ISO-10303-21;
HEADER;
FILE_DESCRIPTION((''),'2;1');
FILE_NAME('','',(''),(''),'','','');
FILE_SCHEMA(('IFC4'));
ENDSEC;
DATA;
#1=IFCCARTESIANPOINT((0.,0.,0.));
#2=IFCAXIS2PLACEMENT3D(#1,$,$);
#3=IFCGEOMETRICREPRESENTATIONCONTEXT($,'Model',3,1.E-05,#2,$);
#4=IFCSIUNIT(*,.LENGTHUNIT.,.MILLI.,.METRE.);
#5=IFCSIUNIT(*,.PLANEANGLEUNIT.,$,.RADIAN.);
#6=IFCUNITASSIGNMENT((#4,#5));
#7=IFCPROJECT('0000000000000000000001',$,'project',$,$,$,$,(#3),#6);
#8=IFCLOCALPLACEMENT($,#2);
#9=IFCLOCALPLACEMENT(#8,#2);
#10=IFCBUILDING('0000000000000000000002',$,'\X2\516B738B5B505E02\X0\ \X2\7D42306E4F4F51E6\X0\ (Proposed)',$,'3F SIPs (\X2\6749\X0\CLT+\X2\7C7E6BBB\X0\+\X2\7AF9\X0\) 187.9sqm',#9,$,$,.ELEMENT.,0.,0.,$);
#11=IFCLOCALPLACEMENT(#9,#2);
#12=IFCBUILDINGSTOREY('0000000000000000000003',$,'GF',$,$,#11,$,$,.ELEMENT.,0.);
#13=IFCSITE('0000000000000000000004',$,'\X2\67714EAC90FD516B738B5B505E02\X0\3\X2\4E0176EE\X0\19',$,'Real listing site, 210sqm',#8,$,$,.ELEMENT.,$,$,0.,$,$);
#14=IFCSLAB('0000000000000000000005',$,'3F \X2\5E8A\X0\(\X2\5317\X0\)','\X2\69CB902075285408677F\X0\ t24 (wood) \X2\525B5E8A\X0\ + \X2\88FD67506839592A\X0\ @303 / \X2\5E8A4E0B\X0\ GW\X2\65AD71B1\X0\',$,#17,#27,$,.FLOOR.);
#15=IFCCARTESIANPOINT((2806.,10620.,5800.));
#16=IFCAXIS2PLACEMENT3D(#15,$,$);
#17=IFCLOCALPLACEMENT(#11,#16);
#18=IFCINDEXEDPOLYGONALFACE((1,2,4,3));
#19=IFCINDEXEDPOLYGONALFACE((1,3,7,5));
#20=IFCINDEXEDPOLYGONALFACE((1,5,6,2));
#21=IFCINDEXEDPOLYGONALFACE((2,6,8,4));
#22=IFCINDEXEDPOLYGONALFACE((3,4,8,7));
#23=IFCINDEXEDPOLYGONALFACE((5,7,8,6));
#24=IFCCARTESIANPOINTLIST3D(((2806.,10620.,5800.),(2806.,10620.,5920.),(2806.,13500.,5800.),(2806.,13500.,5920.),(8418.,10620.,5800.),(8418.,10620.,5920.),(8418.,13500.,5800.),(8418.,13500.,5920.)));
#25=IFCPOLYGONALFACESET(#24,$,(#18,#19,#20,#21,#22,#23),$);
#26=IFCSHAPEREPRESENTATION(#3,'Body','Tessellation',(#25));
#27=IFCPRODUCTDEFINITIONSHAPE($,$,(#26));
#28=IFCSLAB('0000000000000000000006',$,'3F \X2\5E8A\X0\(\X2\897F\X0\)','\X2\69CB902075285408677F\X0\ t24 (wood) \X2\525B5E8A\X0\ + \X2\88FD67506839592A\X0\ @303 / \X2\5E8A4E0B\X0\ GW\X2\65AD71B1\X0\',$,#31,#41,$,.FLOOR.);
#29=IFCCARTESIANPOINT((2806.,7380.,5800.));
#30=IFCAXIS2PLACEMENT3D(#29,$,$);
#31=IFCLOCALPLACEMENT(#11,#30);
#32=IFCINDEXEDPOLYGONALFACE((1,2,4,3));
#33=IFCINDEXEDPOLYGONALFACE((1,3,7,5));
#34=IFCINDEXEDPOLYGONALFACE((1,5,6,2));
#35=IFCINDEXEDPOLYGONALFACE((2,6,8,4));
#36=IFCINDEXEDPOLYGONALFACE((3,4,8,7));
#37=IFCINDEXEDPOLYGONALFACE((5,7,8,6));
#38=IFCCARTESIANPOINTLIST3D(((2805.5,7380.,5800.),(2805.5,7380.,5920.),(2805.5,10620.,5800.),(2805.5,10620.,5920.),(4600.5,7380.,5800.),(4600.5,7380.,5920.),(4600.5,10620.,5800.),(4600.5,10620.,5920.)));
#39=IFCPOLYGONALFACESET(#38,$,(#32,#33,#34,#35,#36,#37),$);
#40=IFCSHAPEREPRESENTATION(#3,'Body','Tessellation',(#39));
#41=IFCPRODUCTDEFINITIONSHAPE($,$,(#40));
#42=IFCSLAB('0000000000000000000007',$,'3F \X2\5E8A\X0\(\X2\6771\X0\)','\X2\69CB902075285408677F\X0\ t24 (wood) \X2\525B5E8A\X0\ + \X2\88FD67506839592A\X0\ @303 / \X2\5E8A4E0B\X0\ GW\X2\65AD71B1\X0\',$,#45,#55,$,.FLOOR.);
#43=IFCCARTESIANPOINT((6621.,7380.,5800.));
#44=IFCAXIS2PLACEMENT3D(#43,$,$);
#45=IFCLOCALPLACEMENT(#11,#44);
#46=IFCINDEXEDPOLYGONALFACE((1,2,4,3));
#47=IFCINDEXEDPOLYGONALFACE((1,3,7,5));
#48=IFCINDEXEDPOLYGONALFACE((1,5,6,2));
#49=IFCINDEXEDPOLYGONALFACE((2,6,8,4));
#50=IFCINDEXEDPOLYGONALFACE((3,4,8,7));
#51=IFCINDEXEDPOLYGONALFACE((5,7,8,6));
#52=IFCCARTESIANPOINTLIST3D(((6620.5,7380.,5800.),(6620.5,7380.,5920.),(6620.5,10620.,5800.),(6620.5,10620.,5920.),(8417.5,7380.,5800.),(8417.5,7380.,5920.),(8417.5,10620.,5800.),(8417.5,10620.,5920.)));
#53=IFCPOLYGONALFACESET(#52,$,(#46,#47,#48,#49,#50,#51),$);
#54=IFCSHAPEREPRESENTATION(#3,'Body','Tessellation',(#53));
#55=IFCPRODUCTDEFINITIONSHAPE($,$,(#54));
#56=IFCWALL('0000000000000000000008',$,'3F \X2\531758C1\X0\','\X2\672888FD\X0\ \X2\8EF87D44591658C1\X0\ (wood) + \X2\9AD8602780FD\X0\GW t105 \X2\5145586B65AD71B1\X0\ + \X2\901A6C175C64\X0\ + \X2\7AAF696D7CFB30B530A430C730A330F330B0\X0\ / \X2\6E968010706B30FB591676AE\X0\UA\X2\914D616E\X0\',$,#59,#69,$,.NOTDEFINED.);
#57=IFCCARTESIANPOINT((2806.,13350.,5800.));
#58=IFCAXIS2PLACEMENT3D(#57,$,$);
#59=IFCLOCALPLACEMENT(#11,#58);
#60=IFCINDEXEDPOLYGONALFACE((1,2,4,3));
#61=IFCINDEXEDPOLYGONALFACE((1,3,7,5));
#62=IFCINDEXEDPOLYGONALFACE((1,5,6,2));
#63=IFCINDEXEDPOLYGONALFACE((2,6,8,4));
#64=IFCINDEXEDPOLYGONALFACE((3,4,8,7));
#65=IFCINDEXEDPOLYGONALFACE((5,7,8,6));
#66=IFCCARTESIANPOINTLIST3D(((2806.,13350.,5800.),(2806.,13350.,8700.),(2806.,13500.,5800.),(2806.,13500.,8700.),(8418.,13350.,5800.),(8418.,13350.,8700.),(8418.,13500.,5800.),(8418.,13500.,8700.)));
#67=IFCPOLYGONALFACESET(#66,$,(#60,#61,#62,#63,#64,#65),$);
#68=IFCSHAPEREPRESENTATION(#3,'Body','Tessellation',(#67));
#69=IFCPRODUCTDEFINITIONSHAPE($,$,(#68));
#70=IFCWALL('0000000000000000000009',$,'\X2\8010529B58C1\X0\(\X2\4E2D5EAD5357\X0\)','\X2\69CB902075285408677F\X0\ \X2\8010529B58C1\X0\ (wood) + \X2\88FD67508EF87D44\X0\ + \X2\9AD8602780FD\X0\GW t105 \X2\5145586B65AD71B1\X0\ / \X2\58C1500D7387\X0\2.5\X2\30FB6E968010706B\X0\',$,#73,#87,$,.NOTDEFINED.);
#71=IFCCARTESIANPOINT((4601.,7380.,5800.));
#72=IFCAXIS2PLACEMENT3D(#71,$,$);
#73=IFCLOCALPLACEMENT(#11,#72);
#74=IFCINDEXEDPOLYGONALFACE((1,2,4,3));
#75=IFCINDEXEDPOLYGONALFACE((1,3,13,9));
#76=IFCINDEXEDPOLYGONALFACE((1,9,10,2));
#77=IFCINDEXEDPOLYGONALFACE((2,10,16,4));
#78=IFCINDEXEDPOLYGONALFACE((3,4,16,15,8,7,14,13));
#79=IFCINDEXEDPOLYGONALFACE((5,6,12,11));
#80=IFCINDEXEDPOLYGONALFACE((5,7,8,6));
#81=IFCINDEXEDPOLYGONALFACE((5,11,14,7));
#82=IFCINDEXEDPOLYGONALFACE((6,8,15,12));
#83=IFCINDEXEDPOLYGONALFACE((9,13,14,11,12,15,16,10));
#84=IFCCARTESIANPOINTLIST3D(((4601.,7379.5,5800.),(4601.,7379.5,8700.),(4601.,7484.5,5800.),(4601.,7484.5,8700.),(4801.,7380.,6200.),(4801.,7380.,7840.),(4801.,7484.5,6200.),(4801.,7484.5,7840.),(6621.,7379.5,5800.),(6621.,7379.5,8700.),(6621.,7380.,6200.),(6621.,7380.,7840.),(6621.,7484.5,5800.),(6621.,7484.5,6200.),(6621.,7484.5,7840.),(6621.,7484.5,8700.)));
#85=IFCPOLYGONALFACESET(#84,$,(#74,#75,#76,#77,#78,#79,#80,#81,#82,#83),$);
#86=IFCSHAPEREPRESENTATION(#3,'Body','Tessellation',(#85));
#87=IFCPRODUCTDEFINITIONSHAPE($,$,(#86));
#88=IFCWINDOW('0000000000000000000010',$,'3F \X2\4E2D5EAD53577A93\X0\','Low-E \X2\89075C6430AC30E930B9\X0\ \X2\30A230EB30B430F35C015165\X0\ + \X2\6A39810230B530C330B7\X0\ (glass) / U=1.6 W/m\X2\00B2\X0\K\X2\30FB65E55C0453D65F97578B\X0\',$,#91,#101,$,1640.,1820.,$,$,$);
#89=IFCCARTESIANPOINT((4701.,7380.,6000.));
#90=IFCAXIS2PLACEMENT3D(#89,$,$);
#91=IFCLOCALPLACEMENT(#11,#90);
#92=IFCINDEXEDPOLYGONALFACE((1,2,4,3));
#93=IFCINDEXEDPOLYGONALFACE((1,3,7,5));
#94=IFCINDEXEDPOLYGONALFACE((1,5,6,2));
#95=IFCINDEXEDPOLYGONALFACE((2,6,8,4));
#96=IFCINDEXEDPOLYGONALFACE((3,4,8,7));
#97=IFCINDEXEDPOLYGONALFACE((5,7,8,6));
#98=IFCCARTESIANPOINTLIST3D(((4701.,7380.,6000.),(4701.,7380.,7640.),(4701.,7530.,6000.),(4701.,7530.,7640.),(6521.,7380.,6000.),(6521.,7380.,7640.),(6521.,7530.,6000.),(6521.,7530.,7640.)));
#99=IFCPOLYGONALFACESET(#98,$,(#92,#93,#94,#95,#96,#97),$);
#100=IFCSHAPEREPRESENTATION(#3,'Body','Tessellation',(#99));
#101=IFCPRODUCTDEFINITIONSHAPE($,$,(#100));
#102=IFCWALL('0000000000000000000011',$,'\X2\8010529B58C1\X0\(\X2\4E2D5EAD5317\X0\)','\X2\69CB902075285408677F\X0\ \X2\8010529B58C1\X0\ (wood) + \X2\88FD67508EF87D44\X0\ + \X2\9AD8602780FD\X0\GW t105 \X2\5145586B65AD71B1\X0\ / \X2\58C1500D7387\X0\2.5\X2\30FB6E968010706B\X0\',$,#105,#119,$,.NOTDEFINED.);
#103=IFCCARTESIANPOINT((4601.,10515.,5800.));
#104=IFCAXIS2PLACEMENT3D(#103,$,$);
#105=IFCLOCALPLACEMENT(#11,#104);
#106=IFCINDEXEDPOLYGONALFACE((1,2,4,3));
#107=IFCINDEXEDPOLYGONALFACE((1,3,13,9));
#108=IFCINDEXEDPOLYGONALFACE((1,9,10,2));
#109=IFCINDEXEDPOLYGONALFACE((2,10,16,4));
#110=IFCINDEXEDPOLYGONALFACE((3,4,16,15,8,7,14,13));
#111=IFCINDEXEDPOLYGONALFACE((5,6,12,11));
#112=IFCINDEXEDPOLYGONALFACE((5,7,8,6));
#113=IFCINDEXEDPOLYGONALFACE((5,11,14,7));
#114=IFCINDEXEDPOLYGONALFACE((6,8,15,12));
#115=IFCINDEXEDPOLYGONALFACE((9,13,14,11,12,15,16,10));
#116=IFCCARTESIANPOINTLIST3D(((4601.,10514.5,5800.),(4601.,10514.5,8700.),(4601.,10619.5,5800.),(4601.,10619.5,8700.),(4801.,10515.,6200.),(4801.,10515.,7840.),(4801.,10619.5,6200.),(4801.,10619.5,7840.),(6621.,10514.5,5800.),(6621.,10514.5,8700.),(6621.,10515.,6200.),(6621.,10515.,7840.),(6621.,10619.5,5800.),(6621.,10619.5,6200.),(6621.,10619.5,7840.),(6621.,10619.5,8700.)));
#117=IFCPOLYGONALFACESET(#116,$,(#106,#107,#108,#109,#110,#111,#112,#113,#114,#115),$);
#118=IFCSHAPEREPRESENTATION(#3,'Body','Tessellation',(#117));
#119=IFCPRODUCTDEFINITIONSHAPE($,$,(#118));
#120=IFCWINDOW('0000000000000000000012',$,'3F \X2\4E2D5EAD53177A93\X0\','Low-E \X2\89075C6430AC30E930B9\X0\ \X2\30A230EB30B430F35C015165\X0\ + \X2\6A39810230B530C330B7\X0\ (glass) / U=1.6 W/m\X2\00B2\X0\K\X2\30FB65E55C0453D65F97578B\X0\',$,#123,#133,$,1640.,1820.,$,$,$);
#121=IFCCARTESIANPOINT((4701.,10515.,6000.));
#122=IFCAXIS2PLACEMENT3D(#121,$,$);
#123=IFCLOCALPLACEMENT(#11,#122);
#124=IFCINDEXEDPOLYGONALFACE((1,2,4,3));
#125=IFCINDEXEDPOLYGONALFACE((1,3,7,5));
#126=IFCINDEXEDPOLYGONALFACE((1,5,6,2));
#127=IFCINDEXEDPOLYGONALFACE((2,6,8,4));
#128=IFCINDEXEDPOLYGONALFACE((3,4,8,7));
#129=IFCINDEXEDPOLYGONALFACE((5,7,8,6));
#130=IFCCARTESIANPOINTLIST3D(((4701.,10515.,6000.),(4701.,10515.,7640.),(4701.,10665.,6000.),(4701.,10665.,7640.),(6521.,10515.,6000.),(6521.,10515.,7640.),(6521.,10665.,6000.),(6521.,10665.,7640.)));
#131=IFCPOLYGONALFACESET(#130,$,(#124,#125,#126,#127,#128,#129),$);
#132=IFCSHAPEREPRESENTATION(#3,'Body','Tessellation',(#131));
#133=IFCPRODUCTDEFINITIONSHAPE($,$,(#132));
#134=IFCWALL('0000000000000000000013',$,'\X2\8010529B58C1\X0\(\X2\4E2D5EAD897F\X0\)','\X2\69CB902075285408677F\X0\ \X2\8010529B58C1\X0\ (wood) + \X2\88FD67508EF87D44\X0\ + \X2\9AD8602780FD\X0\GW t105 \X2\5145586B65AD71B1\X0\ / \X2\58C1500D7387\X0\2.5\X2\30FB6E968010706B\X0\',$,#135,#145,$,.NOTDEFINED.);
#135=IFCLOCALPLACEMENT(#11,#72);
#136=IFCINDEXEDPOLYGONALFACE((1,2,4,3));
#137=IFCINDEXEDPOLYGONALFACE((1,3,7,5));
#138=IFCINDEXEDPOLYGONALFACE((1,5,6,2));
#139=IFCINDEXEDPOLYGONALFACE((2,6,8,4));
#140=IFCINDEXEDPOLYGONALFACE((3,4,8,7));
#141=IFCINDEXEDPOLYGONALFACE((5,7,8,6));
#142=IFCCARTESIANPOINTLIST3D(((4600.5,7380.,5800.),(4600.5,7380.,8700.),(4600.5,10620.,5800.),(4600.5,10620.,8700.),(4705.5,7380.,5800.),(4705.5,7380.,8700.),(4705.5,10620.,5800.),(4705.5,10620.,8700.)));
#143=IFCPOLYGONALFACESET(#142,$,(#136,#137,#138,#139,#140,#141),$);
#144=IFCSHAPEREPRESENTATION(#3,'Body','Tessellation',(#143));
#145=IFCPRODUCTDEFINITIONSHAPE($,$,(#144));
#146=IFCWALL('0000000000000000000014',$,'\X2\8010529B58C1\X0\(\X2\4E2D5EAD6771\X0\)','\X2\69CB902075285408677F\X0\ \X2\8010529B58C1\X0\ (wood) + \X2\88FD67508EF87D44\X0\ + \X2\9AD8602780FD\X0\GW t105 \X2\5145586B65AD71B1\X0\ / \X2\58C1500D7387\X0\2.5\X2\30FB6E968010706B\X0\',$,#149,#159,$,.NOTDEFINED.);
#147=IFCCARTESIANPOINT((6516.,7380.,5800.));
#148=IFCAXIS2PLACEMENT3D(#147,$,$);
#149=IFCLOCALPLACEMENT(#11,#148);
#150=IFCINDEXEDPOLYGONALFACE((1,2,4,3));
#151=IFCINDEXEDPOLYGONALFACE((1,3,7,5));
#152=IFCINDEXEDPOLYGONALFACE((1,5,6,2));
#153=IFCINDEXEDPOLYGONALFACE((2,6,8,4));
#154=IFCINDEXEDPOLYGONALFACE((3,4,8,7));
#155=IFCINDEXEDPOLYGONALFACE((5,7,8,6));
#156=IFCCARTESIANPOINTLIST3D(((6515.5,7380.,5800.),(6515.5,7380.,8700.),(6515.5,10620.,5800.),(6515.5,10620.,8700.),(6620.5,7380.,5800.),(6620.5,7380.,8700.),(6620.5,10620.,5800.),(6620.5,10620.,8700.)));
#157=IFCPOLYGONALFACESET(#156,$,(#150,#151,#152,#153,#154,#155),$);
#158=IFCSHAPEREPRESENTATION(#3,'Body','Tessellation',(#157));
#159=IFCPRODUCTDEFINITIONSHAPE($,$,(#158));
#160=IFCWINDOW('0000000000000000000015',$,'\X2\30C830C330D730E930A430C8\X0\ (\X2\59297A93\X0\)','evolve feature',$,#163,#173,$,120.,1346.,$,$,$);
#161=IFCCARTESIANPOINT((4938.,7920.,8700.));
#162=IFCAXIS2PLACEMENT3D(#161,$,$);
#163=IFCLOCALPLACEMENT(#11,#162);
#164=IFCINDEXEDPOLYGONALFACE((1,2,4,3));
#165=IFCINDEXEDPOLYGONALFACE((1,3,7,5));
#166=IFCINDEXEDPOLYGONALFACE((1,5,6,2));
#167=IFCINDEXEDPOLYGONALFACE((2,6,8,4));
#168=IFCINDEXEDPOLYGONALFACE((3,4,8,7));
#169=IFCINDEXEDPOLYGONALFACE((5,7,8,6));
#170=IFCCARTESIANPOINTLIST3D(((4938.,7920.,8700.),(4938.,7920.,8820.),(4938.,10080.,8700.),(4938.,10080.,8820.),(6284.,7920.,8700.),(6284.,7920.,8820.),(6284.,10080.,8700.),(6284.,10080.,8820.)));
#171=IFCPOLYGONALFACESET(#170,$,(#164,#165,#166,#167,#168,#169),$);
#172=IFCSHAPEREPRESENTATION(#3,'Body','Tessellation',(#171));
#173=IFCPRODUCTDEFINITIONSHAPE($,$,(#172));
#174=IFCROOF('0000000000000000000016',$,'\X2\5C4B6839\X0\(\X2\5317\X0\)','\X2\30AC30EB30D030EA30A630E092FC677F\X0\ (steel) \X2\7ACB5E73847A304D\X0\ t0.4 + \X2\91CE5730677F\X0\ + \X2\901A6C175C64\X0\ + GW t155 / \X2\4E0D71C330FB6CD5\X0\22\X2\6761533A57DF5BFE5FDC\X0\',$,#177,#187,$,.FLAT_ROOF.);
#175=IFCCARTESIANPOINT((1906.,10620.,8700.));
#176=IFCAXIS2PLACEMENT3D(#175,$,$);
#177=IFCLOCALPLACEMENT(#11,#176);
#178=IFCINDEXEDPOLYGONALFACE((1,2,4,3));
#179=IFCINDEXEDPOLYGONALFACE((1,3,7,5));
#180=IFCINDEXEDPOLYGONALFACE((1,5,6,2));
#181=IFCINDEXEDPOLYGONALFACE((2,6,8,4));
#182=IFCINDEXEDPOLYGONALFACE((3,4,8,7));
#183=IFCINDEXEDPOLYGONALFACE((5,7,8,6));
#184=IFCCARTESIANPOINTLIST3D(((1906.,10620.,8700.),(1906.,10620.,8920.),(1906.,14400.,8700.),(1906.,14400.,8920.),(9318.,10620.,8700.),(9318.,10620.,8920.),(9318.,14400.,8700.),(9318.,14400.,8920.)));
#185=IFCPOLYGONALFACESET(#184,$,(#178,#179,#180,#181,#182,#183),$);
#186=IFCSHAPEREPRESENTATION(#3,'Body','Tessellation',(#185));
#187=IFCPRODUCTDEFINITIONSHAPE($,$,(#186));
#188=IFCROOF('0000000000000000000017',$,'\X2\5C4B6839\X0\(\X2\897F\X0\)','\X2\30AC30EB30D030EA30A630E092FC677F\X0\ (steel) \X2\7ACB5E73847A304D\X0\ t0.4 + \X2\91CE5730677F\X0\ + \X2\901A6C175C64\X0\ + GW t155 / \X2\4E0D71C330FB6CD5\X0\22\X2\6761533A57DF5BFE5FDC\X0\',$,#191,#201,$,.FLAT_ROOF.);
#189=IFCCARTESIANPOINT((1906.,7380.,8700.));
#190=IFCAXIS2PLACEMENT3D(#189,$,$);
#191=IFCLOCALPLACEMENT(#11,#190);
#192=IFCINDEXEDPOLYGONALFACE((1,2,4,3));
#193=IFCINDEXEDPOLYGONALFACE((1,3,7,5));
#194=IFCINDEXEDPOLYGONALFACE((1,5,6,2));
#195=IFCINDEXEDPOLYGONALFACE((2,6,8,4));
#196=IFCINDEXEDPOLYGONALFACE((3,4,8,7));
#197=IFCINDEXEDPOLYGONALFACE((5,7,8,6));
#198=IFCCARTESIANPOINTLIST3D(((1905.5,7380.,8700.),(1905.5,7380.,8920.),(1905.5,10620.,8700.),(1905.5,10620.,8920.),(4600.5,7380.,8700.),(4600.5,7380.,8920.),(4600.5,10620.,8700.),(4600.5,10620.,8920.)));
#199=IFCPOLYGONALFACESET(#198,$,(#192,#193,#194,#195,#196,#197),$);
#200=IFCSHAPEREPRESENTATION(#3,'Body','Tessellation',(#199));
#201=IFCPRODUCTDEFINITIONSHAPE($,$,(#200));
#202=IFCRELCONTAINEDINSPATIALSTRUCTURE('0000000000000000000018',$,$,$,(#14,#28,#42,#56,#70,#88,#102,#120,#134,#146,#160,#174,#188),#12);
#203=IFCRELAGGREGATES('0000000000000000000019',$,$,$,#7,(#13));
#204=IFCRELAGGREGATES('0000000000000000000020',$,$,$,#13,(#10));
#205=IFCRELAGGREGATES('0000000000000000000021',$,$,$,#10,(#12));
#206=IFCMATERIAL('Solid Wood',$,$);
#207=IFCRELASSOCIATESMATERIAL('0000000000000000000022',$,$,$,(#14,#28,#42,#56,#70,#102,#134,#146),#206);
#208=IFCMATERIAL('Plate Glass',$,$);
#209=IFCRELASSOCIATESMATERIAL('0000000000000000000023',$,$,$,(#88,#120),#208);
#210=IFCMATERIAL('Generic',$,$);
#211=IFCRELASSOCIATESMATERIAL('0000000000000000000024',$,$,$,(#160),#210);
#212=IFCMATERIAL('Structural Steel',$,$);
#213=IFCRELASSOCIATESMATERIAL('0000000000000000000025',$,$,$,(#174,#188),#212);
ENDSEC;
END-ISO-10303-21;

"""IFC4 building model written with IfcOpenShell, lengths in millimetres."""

from ifc_helpers import new_model, si_unit, frame, frame_2d, origin, place, context, project, spatial, rectangle, extrude, material, element, fill, save


model = new_model("IFC4")

# Units and contexts
model_context = context("Model", 3, precision=1e-05, world=origin())
ifc_project = project(units=[si_unit("LENGTHUNIT", "METRE", prefix="MILLI"), si_unit("PLANEANGLEUNIT", "RADIAN")], contexts=[model_context])

# Site, building, storey
site_placement = place(None, origin())
site = spatial("IfcSite", under=ifc_project, at=site_placement, Name="東京都八王子市3丁目19", ObjectType="Real listing site, 210sqm", CompositionType="ELEMENT", RefElevation=0.0)
building_placement = place(site_placement, origin())
building = spatial("IfcBuilding", under=site, at=building_placement, Name="八王子市 終の住処 (Proposed)", ObjectType="3F SIPs (杉CLT+籾殻+竹) 187.9sqm", CompositionType="ELEMENT", ElevationOfRefHeight=0.0, ElevationOfTerrain=0.0)
storey_placement = place(building_placement, origin())
storey = spatial("IfcBuildingStorey", under=building, at=storey_placement, Name="GF", CompositionType="ELEMENT", Elevation=0.0)

# Slabs
ifc_material_1 = material(Name="Solid Wood")
slab_1_placement = place(storey_placement, frame((2806.0, 10620.0, 5800.0)))
element("IfcSlab", 1, at=slab_1_placement, inside=storey, material=ifc_material_1, Name="3F 床(北)", Description="構造用合板 t24 (wood) 剛床 + 製材根太 @303 / 床下 GW断熱", PredefinedType="FLOOR", context=model_context, shape_type="SweptSolid", body=[
    extrude(rectangle(XDim=5612.0, YDim=2880.0, at=frame_2d((2806.0, 1440.0))), frame((2806.0, 10620.0, 5800.0)), (0.0, 0.0, 1.0), 120.0),
])
slab_2_placement = place(storey_placement, frame((2806.0, 7380.0, 5800.0)))
element("IfcSlab", 2, at=slab_2_placement, inside=storey, material=ifc_material_1, Name="3F 床(西)", Description="構造用合板 t24 (wood) 剛床 + 製材根太 @303 / 床下 GW断熱", PredefinedType="FLOOR", context=model_context, shape_type="SweptSolid", body=[
    extrude(rectangle(XDim=1795.0, YDim=3240.0, at=frame_2d((897.0, 1620.0))), frame((2806.0, 7380.0, 5800.0)), (0.0, 0.0, 1.0), 120.0),
])
slab_3_placement = place(storey_placement, frame((6621.0, 7380.0, 5800.0)))
element("IfcSlab", 3, at=slab_3_placement, inside=storey, material=ifc_material_1, Name="3F 床(東)", Description="構造用合板 t24 (wood) 剛床 + 製材根太 @303 / 床下 GW断熱", PredefinedType="FLOOR", context=model_context, shape_type="SweptSolid", body=[
    extrude(rectangle(XDim=1797.0, YDim=3240.0, at=frame_2d((898.0, 1620.0))), frame((6621.0, 7380.0, 5800.0)), (0.0, 0.0, 1.0), 120.0),
])

# Wall
wall_1_placement = place(storey_placement, frame((2806.0, 13350.0, 5800.0)))
element("IfcWall", 4, at=wall_1_placement, inside=storey, material=ifc_material_1, Name="3F 北壁", Description="木製 軸組外壁 (wood) + 高性能GW t105 充填断熱 + 通気層 + 窯業系サイディング / 準耐火・外皮UA配慮", PredefinedType="NOTDEFINED", context=model_context, shape_type="SweptSolid", body=[
    extrude(rectangle(XDim=5612.0, YDim=150.0, at=frame_2d((2806.0, 75.0))), frame((2806.0, 13350.0, 5800.0)), (0.0, 0.0, 1.0), 2900.0),
])

# Walls, openings, windows
wall_2_placement = place(storey_placement, frame((4601.0, 7380.0, 5800.0)))
wall_2 = element("IfcWall", 5, at=wall_2_placement, inside=storey, material=ifc_material_1, Name="耐力壁(中庭南)", Description="構造用合板 耐力壁 (wood) + 製材軸組 + 高性能GW t105 充填断熱 / 壁倍率2.5・準耐火", PredefinedType="NOTDEFINED", context=model_context, shape_type="SweptSolid", body=[
    extrude(rectangle(XDim=2020.0, YDim=105.0, at=frame_2d((1010.0, 52.0))), frame((4601.0, 7380.0, 5800.0)), (0.0, 0.0, 1.0), 2900.0),
])
opening_1_placement = place(storey_placement, frame((4701.0, 7380.0, 6000.0)))
opening_1 = element("IfcOpeningElement", 6, at=opening_1_placement, cuts=wall_2, PredefinedType="NOTDEFINED", context=model_context, shape_type="SweptSolid", body=[
    extrude(rectangle(XDim=1820.0, YDim=150.0, at=frame_2d((910.0, 75.0))), frame((4701.0, 7380.0, 6000.0)), (0.0, 0.0, 1.0), 1640.0),
])
ifc_material_2 = material(Name="Plate Glass")
window_1_placement = place(storey_placement, frame((4701.0, 7380.0, 6000.0)))
window_1 = element("IfcWindow", 7, at=window_1_placement, inside=storey, material=ifc_material_2, Name="3F 中庭南窓", Description="Low-E 複層ガラス アルゴン封入 + 樹脂サッシ (glass) / U=1.6 W/m²K・日射取得型", OverallHeight=1640.0, OverallWidth=1820.0, context=model_context, shape_type="SweptSolid", body=[
    extrude(rectangle(XDim=1820.0, YDim=150.0, at=frame_2d((910.0, 75.0))), frame((4701.0, 7380.0, 6000.0)), (0.0, 0.0, 1.0), 1640.0),
])
fill(opening_1, window_1)
wall_3_placement = place(storey_placement, frame((4601.0, 10515.0, 5800.0)))
wall_3 = element("IfcWall", 8, at=wall_3_placement, inside=storey, material=ifc_material_1, Name="耐力壁(中庭北)", Description="構造用合板 耐力壁 (wood) + 製材軸組 + 高性能GW t105 充填断熱 / 壁倍率2.5・準耐火", PredefinedType="NOTDEFINED", context=model_context, shape_type="SweptSolid", body=[
    extrude(rectangle(XDim=2020.0, YDim=105.0, at=frame_2d((1010.0, 52.0))), frame((4601.0, 10515.0, 5800.0)), (0.0, 0.0, 1.0), 2900.0),
])
opening_2_placement = place(storey_placement, frame((4701.0, 10515.0, 6000.0)))
opening_2 = element("IfcOpeningElement", 9, at=opening_2_placement, cuts=wall_3, PredefinedType="NOTDEFINED", context=model_context, shape_type="SweptSolid", body=[
    extrude(rectangle(XDim=1820.0, YDim=150.0, at=frame_2d((910.0, 75.0))), frame((4701.0, 10515.0, 6000.0)), (0.0, 0.0, 1.0), 1640.0),
])
window_2_placement = place(storey_placement, frame((4701.0, 10515.0, 6000.0)))
window_2 = element("IfcWindow", 10, at=window_2_placement, inside=storey, material=ifc_material_2, Name="3F 中庭北窓", Description="Low-E 複層ガラス アルゴン封入 + 樹脂サッシ (glass) / U=1.6 W/m²K・日射取得型", OverallHeight=1640.0, OverallWidth=1820.0, context=model_context, shape_type="SweptSolid", body=[
    extrude(rectangle(XDim=1820.0, YDim=150.0, at=frame_2d((910.0, 75.0))), frame((4701.0, 10515.0, 6000.0)), (0.0, 0.0, 1.0), 1640.0),
])
fill(opening_2, window_2)

# Walls
wall_4_placement = place(storey_placement, frame((4601.0, 7380.0, 5800.0)))
element("IfcWall", 11, at=wall_4_placement, inside=storey, material=ifc_material_1, Name="耐力壁(中庭西)", Description="構造用合板 耐力壁 (wood) + 製材軸組 + 高性能GW t105 充填断熱 / 壁倍率2.5・準耐火", PredefinedType="NOTDEFINED", context=model_context, shape_type="SweptSolid", body=[
    extrude(rectangle(XDim=105.0, YDim=3240.0, at=frame_2d((52.0, 1620.0))), frame((4601.0, 7380.0, 5800.0)), (0.0, 0.0, 1.0), 2900.0),
])
wall_5_placement = place(storey_placement, frame((6516.0, 7380.0, 5800.0)))
element("IfcWall", 12, at=wall_5_placement, inside=storey, material=ifc_material_1, Name="耐力壁(中庭東)", Description="構造用合板 耐力壁 (wood) + 製材軸組 + 高性能GW t105 充填断熱 / 壁倍率2.5・準耐火", PredefinedType="NOTDEFINED", context=model_context, shape_type="SweptSolid", body=[
    extrude(rectangle(XDim=105.0, YDim=3240.0, at=frame_2d((52.0, 1620.0))), frame((6516.0, 7380.0, 5800.0)), (0.0, 0.0, 1.0), 2900.0),
])

# Window
ifc_material_3 = material(Name="Generic")
window_3_placement = place(storey_placement, frame((4938.0, 7920.0, 8700.0)))
element("IfcWindow", 13, at=window_3_placement, inside=storey, material=ifc_material_3, Name="トップライト (天窓)", Description="evolve feature", OverallHeight=120.0, OverallWidth=1346.0, context=model_context, shape_type="SweptSolid", body=[
    extrude(rectangle(XDim=1346.0, YDim=2160.0, at=frame_2d((673.0, 1080.0))), frame((4938.0, 7920.0, 8700.0)), (0.0, 0.0, 1.0), 120.0),
])

# Roofs
ifc_material_4 = material(Name="Structural Steel")
for number, where, name in (
    (14, (1906.0, 10620.0, 8700.0), "屋根(北)"),
):
    element("IfcRoof", number, at=place(storey_placement, frame(where)), inside=storey, material=ifc_material_4, Name=name, Description="ガルバリウム鋼板 (steel) 立平葺き t0.4 + 野地板 + 通気層 + GW t155 / 不燃・法22条区域対応", PredefinedType="FLAT_ROOF", context=model_context, shape_type="SweptSolid", body=[
        extrude(rectangle(XDim=7412.0, YDim=3780.0, at=frame_2d((3706.0, 1890.0))), frame((1906.0, 10620.0, 8700.0)), (0.0, 0.0, 1.0), 220.0),
    ])
roof_1_placement = place(storey_placement, frame((1906.0, 7380.0, 8700.0)))
element("IfcRoof", 15, at=roof_1_placement, inside=storey, material=ifc_material_4, Name="屋根(西)", Description="ガルバリウム鋼板 (steel) 立平葺き t0.4 + 野地板 + 通気層 + GW t155 / 不燃・法22条区域対応", PredefinedType="FLAT_ROOF", context=model_context, shape_type="SweptSolid", body=[
    extrude(rectangle(XDim=2695.0, YDim=3240.0, at=frame_2d((1347.0, 1620.0))), frame((1906.0, 7380.0, 8700.0)), (0.0, 0.0, 1.0), 220.0),
])

save(model, "model.ifc")
